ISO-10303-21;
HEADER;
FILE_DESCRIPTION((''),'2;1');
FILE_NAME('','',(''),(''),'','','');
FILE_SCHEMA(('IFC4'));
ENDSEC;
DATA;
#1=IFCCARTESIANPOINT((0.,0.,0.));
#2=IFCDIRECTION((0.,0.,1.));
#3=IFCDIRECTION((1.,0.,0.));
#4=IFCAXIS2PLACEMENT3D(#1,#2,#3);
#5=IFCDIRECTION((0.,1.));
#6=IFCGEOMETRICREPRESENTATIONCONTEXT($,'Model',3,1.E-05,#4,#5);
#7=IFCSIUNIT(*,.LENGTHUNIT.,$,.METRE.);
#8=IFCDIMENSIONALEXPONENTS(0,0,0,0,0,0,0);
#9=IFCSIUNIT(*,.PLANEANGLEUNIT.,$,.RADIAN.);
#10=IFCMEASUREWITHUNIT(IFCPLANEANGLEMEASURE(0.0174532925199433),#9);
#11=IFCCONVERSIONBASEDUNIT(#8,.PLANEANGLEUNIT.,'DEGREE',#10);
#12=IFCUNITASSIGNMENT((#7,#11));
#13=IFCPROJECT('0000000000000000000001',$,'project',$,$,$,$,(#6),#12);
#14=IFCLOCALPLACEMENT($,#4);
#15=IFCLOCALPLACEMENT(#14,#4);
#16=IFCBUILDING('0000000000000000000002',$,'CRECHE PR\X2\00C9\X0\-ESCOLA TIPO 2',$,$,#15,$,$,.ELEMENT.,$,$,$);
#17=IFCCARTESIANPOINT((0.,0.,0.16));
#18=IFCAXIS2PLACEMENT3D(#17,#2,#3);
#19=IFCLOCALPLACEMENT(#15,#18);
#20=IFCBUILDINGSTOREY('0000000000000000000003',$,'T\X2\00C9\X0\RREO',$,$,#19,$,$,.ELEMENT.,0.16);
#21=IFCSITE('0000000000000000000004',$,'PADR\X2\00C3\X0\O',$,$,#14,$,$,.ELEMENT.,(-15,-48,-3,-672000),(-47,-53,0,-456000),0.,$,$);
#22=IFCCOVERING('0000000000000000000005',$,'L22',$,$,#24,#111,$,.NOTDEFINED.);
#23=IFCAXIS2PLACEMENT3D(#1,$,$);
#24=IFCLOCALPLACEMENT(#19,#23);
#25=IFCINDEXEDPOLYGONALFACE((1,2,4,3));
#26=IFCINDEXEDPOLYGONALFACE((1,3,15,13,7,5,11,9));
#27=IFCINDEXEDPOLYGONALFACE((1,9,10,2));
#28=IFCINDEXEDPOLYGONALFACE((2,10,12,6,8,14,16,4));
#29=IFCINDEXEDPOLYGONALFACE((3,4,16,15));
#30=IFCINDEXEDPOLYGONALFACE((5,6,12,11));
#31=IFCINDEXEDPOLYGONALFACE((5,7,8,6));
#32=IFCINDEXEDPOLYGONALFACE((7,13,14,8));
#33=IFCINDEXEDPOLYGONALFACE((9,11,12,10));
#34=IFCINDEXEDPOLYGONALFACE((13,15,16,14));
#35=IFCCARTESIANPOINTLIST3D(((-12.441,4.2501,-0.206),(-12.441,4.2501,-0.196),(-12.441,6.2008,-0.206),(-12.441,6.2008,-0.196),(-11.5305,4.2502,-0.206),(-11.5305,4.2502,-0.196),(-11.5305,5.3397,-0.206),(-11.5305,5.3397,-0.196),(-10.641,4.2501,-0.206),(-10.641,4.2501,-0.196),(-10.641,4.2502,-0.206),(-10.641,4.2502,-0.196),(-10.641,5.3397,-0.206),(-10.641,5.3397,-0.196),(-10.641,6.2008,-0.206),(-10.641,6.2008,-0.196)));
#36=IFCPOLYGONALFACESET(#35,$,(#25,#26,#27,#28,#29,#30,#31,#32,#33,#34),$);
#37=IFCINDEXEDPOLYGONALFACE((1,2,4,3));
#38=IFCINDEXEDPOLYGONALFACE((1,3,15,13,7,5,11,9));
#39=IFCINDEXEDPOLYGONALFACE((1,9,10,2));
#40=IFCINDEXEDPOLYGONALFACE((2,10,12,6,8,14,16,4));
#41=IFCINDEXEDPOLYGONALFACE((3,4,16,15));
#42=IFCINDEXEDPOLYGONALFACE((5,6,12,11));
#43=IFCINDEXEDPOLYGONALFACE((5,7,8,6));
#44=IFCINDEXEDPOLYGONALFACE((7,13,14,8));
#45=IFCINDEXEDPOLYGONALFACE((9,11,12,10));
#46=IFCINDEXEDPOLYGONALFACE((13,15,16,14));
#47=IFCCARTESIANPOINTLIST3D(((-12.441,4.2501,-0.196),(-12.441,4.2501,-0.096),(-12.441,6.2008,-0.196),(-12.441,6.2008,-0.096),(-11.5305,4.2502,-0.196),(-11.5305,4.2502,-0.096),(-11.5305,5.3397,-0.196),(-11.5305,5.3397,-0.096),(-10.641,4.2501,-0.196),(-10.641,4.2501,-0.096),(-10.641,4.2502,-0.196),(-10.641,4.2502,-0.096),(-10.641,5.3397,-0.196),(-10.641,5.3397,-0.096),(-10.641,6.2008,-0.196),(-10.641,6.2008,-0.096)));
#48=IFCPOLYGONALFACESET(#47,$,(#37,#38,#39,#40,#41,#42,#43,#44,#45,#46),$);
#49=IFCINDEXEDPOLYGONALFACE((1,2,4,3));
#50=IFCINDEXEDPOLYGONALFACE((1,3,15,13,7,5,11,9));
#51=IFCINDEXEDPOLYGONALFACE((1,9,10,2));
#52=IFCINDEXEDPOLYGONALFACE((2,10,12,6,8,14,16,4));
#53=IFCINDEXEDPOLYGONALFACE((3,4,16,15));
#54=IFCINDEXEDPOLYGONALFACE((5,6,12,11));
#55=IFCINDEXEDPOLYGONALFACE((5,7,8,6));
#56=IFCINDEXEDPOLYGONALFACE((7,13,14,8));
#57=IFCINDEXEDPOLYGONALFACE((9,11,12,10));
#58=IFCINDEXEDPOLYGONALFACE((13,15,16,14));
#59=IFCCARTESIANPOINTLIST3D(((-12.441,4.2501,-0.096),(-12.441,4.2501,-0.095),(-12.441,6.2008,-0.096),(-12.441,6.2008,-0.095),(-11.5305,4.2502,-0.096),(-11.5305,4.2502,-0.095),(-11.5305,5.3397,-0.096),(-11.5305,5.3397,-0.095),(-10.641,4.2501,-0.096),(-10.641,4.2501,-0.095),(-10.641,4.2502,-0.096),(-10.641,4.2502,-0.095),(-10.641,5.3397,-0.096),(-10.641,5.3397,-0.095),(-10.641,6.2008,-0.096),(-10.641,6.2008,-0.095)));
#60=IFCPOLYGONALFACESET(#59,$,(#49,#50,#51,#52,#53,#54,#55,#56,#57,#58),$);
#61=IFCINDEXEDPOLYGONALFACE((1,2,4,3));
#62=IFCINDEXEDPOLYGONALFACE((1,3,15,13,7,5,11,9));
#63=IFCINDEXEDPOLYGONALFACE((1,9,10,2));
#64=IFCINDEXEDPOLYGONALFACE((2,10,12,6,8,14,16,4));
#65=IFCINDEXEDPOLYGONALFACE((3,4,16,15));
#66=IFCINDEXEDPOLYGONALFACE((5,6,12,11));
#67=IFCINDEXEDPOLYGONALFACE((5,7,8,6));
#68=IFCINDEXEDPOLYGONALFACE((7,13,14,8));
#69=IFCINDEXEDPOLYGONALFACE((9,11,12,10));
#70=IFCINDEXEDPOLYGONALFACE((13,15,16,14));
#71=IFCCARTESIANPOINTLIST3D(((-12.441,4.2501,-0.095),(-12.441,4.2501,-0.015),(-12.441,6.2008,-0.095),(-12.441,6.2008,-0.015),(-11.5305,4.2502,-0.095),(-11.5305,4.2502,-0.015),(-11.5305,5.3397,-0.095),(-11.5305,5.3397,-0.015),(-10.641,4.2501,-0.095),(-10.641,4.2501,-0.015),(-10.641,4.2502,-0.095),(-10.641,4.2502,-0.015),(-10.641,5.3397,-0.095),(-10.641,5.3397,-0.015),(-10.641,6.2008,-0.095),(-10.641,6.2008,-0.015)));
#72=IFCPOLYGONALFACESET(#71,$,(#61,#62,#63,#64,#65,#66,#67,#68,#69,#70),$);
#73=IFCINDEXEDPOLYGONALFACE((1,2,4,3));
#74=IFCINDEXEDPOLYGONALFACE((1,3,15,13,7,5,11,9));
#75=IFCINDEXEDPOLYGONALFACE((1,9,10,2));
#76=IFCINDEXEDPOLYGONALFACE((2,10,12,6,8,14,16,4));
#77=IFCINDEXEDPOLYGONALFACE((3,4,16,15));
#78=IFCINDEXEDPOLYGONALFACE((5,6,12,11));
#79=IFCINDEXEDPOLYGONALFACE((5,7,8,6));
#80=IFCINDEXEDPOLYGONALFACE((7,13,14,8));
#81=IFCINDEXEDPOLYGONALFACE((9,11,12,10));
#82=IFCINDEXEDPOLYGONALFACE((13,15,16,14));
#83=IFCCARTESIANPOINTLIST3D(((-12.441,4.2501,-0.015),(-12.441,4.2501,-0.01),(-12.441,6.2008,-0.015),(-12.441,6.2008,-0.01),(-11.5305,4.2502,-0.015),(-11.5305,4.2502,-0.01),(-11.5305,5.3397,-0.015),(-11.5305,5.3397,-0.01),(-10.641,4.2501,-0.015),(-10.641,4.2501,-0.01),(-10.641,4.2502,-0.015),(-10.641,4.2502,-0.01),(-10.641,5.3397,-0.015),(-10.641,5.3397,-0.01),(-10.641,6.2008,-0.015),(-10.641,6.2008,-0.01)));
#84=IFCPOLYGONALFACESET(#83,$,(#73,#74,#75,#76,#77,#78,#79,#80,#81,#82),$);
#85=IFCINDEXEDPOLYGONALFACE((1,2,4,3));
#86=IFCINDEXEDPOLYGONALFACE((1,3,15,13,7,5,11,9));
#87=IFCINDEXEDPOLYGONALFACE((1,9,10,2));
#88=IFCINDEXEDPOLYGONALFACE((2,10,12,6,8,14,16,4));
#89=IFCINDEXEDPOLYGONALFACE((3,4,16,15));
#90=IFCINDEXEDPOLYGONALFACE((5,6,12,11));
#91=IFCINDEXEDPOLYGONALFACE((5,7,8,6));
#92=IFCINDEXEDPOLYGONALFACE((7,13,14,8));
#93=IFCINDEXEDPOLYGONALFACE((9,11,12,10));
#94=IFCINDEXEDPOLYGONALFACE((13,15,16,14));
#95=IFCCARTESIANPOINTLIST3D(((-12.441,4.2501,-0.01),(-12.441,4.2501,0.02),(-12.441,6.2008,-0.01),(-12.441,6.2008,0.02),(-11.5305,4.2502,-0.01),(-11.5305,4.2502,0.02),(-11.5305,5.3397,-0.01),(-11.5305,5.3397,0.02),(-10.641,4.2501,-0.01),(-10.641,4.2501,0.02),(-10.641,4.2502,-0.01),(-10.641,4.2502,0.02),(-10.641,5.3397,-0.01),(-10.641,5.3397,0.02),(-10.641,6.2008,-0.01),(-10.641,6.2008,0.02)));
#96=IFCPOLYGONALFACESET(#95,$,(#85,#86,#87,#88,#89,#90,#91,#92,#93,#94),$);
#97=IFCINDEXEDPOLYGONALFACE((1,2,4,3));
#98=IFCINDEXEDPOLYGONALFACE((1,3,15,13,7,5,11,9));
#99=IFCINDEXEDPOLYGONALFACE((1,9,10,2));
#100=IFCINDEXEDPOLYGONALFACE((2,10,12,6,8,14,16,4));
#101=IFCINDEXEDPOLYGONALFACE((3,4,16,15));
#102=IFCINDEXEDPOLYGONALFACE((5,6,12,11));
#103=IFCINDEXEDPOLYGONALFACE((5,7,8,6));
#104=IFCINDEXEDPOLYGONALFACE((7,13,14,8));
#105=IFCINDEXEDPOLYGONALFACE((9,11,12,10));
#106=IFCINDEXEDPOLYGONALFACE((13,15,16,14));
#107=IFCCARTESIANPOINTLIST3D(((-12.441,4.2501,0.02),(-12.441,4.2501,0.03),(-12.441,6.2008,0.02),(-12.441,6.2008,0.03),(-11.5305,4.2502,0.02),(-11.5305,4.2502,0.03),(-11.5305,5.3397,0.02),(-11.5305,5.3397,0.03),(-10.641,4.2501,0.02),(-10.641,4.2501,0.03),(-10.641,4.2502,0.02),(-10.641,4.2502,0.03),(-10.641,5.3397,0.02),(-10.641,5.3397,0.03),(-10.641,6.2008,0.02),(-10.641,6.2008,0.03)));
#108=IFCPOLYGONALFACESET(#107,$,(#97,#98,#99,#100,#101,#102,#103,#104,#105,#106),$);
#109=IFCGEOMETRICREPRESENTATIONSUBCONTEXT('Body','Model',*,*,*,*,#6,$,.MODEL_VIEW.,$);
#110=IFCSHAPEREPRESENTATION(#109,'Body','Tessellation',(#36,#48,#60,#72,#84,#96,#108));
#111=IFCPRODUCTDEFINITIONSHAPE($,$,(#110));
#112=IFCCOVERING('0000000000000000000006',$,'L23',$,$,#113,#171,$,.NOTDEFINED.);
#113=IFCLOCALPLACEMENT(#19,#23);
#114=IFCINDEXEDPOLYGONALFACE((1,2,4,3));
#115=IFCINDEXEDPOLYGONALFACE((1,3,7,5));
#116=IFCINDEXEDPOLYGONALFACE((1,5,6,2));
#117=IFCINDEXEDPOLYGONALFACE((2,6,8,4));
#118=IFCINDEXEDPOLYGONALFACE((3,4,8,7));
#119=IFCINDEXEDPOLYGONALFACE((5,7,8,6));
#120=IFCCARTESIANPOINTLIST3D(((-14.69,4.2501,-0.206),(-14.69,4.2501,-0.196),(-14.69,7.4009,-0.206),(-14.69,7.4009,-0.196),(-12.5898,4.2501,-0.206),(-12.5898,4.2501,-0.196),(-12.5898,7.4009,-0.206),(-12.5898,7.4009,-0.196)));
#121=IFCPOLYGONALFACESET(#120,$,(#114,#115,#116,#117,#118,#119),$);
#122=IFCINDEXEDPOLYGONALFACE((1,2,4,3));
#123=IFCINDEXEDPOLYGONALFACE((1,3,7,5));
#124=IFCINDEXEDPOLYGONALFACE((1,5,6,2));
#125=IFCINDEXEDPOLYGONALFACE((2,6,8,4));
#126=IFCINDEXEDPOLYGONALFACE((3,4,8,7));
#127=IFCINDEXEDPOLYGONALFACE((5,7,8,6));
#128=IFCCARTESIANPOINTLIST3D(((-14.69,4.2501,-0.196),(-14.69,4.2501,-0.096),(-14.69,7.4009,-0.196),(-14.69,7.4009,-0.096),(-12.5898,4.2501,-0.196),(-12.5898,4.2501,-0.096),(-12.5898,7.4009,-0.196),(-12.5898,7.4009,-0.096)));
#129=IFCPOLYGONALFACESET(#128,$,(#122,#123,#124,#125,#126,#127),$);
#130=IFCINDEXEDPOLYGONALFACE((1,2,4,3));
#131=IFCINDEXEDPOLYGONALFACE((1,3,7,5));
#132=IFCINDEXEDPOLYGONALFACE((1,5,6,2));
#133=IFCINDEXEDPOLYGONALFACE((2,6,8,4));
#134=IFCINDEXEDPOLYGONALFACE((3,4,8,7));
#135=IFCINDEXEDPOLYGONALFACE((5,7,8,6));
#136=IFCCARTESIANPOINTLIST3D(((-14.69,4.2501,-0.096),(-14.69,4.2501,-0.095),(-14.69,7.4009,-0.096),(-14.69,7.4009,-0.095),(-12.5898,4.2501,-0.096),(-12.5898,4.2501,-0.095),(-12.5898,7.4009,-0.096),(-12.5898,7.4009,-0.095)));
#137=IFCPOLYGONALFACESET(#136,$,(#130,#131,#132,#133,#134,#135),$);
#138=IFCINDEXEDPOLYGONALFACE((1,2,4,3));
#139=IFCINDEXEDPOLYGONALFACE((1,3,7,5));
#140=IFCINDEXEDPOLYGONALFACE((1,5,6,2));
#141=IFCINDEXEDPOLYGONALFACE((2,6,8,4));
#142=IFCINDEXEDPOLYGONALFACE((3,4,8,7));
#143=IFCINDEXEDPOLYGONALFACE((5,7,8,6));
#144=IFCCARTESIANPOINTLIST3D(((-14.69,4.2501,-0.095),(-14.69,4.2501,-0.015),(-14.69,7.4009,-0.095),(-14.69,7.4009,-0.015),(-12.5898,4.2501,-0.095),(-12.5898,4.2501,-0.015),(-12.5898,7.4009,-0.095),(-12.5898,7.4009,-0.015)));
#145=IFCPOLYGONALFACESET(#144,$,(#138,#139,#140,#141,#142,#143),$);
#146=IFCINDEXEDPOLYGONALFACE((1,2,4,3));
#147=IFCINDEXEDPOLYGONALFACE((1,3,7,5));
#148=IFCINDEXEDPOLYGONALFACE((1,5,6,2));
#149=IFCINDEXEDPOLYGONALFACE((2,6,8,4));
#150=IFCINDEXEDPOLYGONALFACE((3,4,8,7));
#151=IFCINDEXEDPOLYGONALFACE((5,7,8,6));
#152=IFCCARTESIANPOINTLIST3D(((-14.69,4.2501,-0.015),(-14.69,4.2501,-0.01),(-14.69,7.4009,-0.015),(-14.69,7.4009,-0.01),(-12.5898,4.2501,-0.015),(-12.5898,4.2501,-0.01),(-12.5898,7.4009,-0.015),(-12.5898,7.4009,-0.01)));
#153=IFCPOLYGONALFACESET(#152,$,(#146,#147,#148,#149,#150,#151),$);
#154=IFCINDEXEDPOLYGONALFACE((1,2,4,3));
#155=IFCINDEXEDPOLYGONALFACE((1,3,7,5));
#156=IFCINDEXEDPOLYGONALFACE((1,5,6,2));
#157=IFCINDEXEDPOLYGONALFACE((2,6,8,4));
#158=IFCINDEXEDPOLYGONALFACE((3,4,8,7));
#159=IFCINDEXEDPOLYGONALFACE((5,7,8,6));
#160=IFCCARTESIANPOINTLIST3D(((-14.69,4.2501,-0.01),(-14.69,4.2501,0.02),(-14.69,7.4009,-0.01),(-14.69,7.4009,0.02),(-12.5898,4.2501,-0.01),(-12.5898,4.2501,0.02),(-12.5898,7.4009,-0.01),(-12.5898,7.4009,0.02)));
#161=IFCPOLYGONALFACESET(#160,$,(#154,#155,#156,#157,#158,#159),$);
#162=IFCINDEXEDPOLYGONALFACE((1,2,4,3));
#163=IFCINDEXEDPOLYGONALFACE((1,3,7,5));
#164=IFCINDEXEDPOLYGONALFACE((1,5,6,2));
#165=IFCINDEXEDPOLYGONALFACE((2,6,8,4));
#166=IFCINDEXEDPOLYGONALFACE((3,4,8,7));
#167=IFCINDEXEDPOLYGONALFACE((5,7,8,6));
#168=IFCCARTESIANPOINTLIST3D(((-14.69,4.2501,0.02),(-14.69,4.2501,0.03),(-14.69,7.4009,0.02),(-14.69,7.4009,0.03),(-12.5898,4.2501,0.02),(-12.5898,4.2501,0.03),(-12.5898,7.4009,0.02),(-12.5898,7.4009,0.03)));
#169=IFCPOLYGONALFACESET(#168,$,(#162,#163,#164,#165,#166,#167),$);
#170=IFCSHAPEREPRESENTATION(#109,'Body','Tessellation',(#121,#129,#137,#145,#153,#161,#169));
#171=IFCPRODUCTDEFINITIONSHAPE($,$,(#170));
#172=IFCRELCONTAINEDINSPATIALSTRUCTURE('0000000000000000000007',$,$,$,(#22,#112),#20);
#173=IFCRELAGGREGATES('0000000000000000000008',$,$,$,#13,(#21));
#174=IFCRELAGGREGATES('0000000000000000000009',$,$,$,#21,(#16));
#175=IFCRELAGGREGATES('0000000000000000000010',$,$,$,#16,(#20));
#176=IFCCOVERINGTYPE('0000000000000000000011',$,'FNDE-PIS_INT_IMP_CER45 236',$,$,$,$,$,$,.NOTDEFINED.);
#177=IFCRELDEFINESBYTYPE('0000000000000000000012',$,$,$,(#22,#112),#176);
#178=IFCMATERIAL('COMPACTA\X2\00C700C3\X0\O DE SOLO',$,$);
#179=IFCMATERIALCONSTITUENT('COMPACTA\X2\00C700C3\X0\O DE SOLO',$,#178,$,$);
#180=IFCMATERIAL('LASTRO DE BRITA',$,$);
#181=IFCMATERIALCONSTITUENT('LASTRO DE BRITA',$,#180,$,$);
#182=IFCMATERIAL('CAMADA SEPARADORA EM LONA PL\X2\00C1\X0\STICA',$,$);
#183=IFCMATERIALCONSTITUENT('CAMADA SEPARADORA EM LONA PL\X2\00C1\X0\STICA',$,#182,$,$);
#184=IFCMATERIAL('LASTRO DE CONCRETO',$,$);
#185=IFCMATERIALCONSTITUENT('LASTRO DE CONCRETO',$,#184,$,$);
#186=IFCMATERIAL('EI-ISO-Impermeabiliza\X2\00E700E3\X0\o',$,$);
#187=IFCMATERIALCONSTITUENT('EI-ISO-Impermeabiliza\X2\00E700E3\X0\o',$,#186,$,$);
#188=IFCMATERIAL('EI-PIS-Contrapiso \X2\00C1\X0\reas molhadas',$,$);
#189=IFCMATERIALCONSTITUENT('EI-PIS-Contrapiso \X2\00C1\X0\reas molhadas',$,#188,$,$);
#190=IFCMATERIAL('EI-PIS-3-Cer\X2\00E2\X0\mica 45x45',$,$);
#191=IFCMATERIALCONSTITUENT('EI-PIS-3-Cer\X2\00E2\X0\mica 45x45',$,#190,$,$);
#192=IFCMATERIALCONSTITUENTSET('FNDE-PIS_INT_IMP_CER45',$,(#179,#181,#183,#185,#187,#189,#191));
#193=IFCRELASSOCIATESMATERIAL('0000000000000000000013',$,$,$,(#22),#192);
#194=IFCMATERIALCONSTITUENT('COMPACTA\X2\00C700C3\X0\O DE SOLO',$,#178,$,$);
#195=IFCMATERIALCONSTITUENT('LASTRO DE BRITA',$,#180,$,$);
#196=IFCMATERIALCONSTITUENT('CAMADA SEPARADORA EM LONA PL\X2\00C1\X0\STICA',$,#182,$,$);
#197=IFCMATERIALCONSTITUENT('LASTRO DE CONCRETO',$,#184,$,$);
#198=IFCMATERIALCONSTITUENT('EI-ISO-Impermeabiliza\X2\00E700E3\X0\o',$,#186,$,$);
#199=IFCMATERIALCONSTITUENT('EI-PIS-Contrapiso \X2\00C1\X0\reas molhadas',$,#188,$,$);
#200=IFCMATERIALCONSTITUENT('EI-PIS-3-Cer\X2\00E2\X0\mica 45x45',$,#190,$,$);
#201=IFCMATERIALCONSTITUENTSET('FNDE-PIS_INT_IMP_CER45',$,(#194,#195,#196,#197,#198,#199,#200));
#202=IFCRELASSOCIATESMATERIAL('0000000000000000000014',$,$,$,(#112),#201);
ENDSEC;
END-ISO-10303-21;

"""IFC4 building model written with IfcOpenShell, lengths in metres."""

from ifc_helpers import new_model, entity, si_unit, converted_unit, direction, frame, origin_with_axes, place, context, subcontext, project, spatial, line, indexed_curve, outline, extrude, material, constituent, constituent_set, type_object, element, save


model = new_model("IFC4")

# Units and contexts
model_context = context("Model", 3, precision=1e-05, world=origin_with_axes(), true_north=direction((0.0, 1.0)))
body_context = subcontext(model_context, "Body", "Model", "MODEL_VIEW")
ifc_project = project(units=[si_unit("LENGTHUNIT", "METRE"), converted_unit("PLANEANGLEUNIT", "DEGREE", entity("IfcPlaneAngleMeasure", 0.0174532925199433), si_unit("PLANEANGLEUNIT", "RADIAN"), dimensions=[0, 0, 0, 0, 0, 0, 0])], contexts=[model_context])

# Site, building, storey
site_placement = place(None, origin_with_axes())
site = spatial("IfcSite", under=ifc_project, at=site_placement, Name="PADRÃO", CompositionType="ELEMENT", RefLatitude=(-15, -48, -3, -672000), RefLongitude=(-47, -53, 0, -456000), RefElevation=0.0)
building_placement = place(site_placement, origin_with_axes())
building = spatial("IfcBuilding", under=site, at=building_placement, Name="CRECHE PRÉ-ESCOLA TIPO 2", CompositionType="ELEMENT")
storey_placement = place(building_placement, frame((0.0, 0.0, 0.16), z_axis=(0.0, 0.0, 1.0), x_axis=(1.0, 0.0, 0.0)))
storey = spatial("IfcBuildingStorey", under=building, at=storey_placement, Name="TÉRREO", CompositionType="ELEMENT", Elevation=0.16)

# Coverings
ifc_material_1 = material(Name="COMPACTAÇÃO DE SOLO")
ifc_material_2 = material(Name="LASTRO DE BRITA")
ifc_constituent_1 = constituent(ifc_material_1, Name="COMPACTAÇÃO DE SOLO")
ifc_constituent_2 = constituent(ifc_material_2, Name="LASTRO DE BRITA")
ifc_material_3 = material(Name="CAMADA SEPARADORA EM LONA PLÁSTICA")
ifc_constituent_3 = constituent(ifc_material_3, Name="CAMADA SEPARADORA EM LONA PLÁSTICA")
ifc_material_4 = material(Name="LASTRO DE CONCRETO")
ifc_constituent_4 = constituent(ifc_material_4, Name="LASTRO DE CONCRETO")
ifc_material_5 = material(Name="EI-ISO-Impermeabilização")
ifc_constituent_5 = constituent(ifc_material_5, Name="EI-ISO-Impermeabilização")
ifc_material_6 = material(Name="EI-PIS-Contrapiso Áreas molhadas")
ifc_constituent_6 = constituent(ifc_material_6, Name="EI-PIS-Contrapiso Áreas molhadas")
ifc_material_7 = material(Name="EI-PIS-3-Cerâmica 45x45")
ifc_constituent_7 = constituent(ifc_material_7, Name="EI-PIS-3-Cerâmica 45x45")
ifc_constituent_set_1 = constituent_set(constituents=[ifc_constituent_1, ifc_constituent_2, ifc_constituent_3, ifc_constituent_4, ifc_constituent_5, ifc_constituent_6, ifc_constituent_7], Name="FNDE-PIS_INT_IMP_CER45")
covering_type_1 = type_object("IfcCoveringType", Name="FNDE-PIS_INT_IMP_CER45 236", PredefinedType="NOTDEFINED")
covering_1_placement = place(storey_placement, frame((-12.441, 6.2008, 0.03), z_axis=(0.0, 0.0, 1.0), x_axis=(1.0, 0.0, 0.0)))
element("IfcCovering", 1, at=covering_1_placement, inside=storey, type_object=covering_type_1, material=ifc_constituent_set_1, Name="L22", PredefinedType="NOTDEFINED", context=body_context, shape_type="SweptSolid", body=[
    extrude(outline(indexed_curve([(0.0, 0.0), (0.0, -1.9508), (1.8, -1.9508), (1.8, -1.9506), (0.9105, -1.9506), (0.9105, -0.8611), (1.8, -0.8611), (1.8, 0.0)], segments=[line(1, 2, 3, 4, 5, 6, 7, 8, 1)])), frame((0.0, 0.0, -0.236), z_axis=(0.0, 0.0, 1.0), x_axis=(1.0, 0.0, 0.0)), (0.0, 0.0, 1.0), 0.01),
    extrude(outline(indexed_curve([(0.0, 0.0), (0.0, -1.9508), (1.8, -1.9508), (1.8, -1.9506), (0.9105, -1.9506), (0.9105, -0.8611), (1.8, -0.8611), (1.8, 0.0)], segments=[line(1, 2, 3, 4, 5, 6, 7, 8, 1)])), frame((0.0, 0.0, -0.226), z_axis=(0.0, 0.0, 1.0), x_axis=(1.0, 0.0, 0.0)), (0.0, 0.0, 1.0), 0.1),
    extrude(outline(indexed_curve([(0.0, 0.0), (0.0, -1.9508), (1.8, -1.9508), (1.8, -1.9506), (0.9105, -1.9506), (0.9105, -0.8611), (1.8, -0.8611), (1.8, 0.0)], segments=[line(1, 2, 3, 4, 5, 6, 7, 8, 1)])), frame((0.0, 0.0, -0.126), z_axis=(0.0, 0.0, 1.0), x_axis=(1.0, 0.0, 0.0)), (0.0, 0.0, 1.0), 0.001),
    extrude(outline(indexed_curve([(0.0, 0.0), (0.0, -1.9508), (1.8, -1.9508), (1.8, -1.9506), (0.9105, -1.9506), (0.9105, -0.8611), (1.8, -0.8611), (1.8, 0.0)], segments=[line(1, 2, 3, 4, 5, 6, 7, 8, 1)])), frame((0.0, 0.0, -0.125), z_axis=(0.0, 0.0, 1.0), x_axis=(1.0, 0.0, 0.0)), (0.0, 0.0, 1.0), 0.08),
    extrude(outline(indexed_curve([(0.0, 0.0), (0.0, -1.9508), (1.8, -1.9508), (1.8, -1.9506), (0.9105, -1.9506), (0.9105, -0.8611), (1.8, -0.8611), (1.8, 0.0)], segments=[line(1, 2, 3, 4, 5, 6, 7, 8, 1)])), frame((0.0, 0.0, -0.045), z_axis=(0.0, 0.0, 1.0), x_axis=(1.0, 0.0, 0.0)), (0.0, 0.0, 1.0), 0.005),
    extrude(outline(indexed_curve([(0.0, 0.0), (0.0, -1.9508), (1.8, -1.9508), (1.8, -1.9506), (0.9105, -1.9506), (0.9105, -0.8611), (1.8, -0.8611), (1.8, 0.0)], segments=[line(1, 2, 3, 4, 5, 6, 7, 8, 1)])), frame((0.0, 0.0, -0.04), z_axis=(0.0, 0.0, 1.0), x_axis=(1.0, 0.0, 0.0)), (0.0, 0.0, 1.0), 0.03),
    extrude(outline(indexed_curve([(0.0, 0.0), (0.0, -1.9508), (1.8, -1.9508), (1.8, -1.9506), (0.9105, -1.9506), (0.9105, -0.8611), (1.8, -0.8611), (1.8, 0.0)], segments=[line(1, 2, 3, 4, 5, 6, 7, 8, 1)])), frame((0.0, 0.0, -0.01), z_axis=(0.0, 0.0, 1.0), x_axis=(1.0, 0.0, 0.0)), (0.0, 0.0, 1.0), 0.01),
])
ifc_constituent_8 = constituent(ifc_material_1, Name="COMPACTAÇÃO DE SOLO")
ifc_constituent_9 = constituent(ifc_material_2, Name="LASTRO DE BRITA")
ifc_constituent_10 = constituent(ifc_material_3, Name="CAMADA SEPARADORA EM LONA PLÁSTICA")
ifc_constituent_11 = constituent(ifc_material_4, Name="LASTRO DE CONCRETO")
ifc_constituent_12 = constituent(ifc_material_5, Name="EI-ISO-Impermeabilização")
ifc_constituent_13 = constituent(ifc_material_6, Name="EI-PIS-Contrapiso Áreas molhadas")
ifc_constituent_14 = constituent(ifc_material_7, Name="EI-PIS-3-Cerâmica 45x45")
ifc_constituent_set_2 = constituent_set(constituents=[ifc_constituent_8, ifc_constituent_9, ifc_constituent_10, ifc_constituent_11, ifc_constituent_12, ifc_constituent_13, ifc_constituent_14], Name="FNDE-PIS_INT_IMP_CER45")
covering_2_placement = place(storey_placement, frame((-14.69, 4.2501, 0.03), z_axis=(0.0, 0.0, 1.0), x_axis=(1.0, 0.0, 0.0)))
element("IfcCovering", 2, at=covering_2_placement, inside=storey, type_object=covering_type_1, material=ifc_constituent_set_2, Name="L23", PredefinedType="NOTDEFINED", context=body_context, shape_type="SweptSolid", body=[
    extrude(outline(indexed_curve([(0.0, 0.0), (2.1002, 0.0), (2.1002, 3.1507), (0.0, 3.1507)], segments=[line(1, 2, 3, 4, 1)])), frame((0.0, 0.0, -0.236), z_axis=(0.0, 0.0, 1.0), x_axis=(1.0, 0.0, 0.0)), (0.0, 0.0, 1.0), 0.01),
    extrude(outline(indexed_curve([(0.0, 0.0), (2.1002, 0.0), (2.1002, 3.1507), (0.0, 3.1507)], segments=[line(1, 2, 3, 4, 1)])), frame((0.0, 0.0, -0.226), z_axis=(0.0, 0.0, 1.0), x_axis=(1.0, 0.0, 0.0)), (0.0, 0.0, 1.0), 0.1),
    extrude(outline(indexed_curve([(0.0, 0.0), (2.1002, 0.0), (2.1002, 3.1507), (0.0, 3.1507)], segments=[line(1, 2, 3, 4, 1)])), frame((0.0, 0.0, -0.126), z_axis=(0.0, 0.0, 1.0), x_axis=(1.0, 0.0, 0.0)), (0.0, 0.0, 1.0), 0.001),
    extrude(outline(indexed_curve([(0.0, 0.0), (2.1002, 0.0), (2.1002, 3.1507), (0.0, 3.1507)], segments=[line(1, 2, 3, 4, 1)])), frame((0.0, 0.0, -0.125), z_axis=(0.0, 0.0, 1.0), x_axis=(1.0, 0.0, 0.0)), (0.0, 0.0, 1.0), 0.08),
    extrude(outline(indexed_curve([(0.0, 0.0), (2.1002, 0.0), (2.1002, 3.1507), (0.0, 3.1507)], segments=[line(1, 2, 3, 4, 1)])), frame((0.0, 0.0, -0.045), z_axis=(0.0, 0.0, 1.0), x_axis=(1.0, 0.0, 0.0)), (0.0, 0.0, 1.0), 0.005),
    extrude(outline(indexed_curve([(0.0, 0.0), (2.1002, 0.0), (2.1002, 3.1507), (0.0, 3.1507)], segments=[line(1, 2, 3, 4, 1)])), frame((0.0, 0.0, -0.04), z_axis=(0.0, 0.0, 1.0), x_axis=(1.0, 0.0, 0.0)), (0.0, 0.0, 1.0), 0.03),
    extrude(outline(indexed_curve([(0.0, 0.0), (2.1002, 0.0), (2.1002, 3.1507), (0.0, 3.1507)], segments=[line(1, 2, 3, 4, 1)])), frame((0.0, 0.0, -0.01), z_axis=(0.0, 0.0, 1.0), x_axis=(1.0, 0.0, 0.0)), (0.0, 0.0, 1.0), 0.01),
])

save(model, "model.ifc")
